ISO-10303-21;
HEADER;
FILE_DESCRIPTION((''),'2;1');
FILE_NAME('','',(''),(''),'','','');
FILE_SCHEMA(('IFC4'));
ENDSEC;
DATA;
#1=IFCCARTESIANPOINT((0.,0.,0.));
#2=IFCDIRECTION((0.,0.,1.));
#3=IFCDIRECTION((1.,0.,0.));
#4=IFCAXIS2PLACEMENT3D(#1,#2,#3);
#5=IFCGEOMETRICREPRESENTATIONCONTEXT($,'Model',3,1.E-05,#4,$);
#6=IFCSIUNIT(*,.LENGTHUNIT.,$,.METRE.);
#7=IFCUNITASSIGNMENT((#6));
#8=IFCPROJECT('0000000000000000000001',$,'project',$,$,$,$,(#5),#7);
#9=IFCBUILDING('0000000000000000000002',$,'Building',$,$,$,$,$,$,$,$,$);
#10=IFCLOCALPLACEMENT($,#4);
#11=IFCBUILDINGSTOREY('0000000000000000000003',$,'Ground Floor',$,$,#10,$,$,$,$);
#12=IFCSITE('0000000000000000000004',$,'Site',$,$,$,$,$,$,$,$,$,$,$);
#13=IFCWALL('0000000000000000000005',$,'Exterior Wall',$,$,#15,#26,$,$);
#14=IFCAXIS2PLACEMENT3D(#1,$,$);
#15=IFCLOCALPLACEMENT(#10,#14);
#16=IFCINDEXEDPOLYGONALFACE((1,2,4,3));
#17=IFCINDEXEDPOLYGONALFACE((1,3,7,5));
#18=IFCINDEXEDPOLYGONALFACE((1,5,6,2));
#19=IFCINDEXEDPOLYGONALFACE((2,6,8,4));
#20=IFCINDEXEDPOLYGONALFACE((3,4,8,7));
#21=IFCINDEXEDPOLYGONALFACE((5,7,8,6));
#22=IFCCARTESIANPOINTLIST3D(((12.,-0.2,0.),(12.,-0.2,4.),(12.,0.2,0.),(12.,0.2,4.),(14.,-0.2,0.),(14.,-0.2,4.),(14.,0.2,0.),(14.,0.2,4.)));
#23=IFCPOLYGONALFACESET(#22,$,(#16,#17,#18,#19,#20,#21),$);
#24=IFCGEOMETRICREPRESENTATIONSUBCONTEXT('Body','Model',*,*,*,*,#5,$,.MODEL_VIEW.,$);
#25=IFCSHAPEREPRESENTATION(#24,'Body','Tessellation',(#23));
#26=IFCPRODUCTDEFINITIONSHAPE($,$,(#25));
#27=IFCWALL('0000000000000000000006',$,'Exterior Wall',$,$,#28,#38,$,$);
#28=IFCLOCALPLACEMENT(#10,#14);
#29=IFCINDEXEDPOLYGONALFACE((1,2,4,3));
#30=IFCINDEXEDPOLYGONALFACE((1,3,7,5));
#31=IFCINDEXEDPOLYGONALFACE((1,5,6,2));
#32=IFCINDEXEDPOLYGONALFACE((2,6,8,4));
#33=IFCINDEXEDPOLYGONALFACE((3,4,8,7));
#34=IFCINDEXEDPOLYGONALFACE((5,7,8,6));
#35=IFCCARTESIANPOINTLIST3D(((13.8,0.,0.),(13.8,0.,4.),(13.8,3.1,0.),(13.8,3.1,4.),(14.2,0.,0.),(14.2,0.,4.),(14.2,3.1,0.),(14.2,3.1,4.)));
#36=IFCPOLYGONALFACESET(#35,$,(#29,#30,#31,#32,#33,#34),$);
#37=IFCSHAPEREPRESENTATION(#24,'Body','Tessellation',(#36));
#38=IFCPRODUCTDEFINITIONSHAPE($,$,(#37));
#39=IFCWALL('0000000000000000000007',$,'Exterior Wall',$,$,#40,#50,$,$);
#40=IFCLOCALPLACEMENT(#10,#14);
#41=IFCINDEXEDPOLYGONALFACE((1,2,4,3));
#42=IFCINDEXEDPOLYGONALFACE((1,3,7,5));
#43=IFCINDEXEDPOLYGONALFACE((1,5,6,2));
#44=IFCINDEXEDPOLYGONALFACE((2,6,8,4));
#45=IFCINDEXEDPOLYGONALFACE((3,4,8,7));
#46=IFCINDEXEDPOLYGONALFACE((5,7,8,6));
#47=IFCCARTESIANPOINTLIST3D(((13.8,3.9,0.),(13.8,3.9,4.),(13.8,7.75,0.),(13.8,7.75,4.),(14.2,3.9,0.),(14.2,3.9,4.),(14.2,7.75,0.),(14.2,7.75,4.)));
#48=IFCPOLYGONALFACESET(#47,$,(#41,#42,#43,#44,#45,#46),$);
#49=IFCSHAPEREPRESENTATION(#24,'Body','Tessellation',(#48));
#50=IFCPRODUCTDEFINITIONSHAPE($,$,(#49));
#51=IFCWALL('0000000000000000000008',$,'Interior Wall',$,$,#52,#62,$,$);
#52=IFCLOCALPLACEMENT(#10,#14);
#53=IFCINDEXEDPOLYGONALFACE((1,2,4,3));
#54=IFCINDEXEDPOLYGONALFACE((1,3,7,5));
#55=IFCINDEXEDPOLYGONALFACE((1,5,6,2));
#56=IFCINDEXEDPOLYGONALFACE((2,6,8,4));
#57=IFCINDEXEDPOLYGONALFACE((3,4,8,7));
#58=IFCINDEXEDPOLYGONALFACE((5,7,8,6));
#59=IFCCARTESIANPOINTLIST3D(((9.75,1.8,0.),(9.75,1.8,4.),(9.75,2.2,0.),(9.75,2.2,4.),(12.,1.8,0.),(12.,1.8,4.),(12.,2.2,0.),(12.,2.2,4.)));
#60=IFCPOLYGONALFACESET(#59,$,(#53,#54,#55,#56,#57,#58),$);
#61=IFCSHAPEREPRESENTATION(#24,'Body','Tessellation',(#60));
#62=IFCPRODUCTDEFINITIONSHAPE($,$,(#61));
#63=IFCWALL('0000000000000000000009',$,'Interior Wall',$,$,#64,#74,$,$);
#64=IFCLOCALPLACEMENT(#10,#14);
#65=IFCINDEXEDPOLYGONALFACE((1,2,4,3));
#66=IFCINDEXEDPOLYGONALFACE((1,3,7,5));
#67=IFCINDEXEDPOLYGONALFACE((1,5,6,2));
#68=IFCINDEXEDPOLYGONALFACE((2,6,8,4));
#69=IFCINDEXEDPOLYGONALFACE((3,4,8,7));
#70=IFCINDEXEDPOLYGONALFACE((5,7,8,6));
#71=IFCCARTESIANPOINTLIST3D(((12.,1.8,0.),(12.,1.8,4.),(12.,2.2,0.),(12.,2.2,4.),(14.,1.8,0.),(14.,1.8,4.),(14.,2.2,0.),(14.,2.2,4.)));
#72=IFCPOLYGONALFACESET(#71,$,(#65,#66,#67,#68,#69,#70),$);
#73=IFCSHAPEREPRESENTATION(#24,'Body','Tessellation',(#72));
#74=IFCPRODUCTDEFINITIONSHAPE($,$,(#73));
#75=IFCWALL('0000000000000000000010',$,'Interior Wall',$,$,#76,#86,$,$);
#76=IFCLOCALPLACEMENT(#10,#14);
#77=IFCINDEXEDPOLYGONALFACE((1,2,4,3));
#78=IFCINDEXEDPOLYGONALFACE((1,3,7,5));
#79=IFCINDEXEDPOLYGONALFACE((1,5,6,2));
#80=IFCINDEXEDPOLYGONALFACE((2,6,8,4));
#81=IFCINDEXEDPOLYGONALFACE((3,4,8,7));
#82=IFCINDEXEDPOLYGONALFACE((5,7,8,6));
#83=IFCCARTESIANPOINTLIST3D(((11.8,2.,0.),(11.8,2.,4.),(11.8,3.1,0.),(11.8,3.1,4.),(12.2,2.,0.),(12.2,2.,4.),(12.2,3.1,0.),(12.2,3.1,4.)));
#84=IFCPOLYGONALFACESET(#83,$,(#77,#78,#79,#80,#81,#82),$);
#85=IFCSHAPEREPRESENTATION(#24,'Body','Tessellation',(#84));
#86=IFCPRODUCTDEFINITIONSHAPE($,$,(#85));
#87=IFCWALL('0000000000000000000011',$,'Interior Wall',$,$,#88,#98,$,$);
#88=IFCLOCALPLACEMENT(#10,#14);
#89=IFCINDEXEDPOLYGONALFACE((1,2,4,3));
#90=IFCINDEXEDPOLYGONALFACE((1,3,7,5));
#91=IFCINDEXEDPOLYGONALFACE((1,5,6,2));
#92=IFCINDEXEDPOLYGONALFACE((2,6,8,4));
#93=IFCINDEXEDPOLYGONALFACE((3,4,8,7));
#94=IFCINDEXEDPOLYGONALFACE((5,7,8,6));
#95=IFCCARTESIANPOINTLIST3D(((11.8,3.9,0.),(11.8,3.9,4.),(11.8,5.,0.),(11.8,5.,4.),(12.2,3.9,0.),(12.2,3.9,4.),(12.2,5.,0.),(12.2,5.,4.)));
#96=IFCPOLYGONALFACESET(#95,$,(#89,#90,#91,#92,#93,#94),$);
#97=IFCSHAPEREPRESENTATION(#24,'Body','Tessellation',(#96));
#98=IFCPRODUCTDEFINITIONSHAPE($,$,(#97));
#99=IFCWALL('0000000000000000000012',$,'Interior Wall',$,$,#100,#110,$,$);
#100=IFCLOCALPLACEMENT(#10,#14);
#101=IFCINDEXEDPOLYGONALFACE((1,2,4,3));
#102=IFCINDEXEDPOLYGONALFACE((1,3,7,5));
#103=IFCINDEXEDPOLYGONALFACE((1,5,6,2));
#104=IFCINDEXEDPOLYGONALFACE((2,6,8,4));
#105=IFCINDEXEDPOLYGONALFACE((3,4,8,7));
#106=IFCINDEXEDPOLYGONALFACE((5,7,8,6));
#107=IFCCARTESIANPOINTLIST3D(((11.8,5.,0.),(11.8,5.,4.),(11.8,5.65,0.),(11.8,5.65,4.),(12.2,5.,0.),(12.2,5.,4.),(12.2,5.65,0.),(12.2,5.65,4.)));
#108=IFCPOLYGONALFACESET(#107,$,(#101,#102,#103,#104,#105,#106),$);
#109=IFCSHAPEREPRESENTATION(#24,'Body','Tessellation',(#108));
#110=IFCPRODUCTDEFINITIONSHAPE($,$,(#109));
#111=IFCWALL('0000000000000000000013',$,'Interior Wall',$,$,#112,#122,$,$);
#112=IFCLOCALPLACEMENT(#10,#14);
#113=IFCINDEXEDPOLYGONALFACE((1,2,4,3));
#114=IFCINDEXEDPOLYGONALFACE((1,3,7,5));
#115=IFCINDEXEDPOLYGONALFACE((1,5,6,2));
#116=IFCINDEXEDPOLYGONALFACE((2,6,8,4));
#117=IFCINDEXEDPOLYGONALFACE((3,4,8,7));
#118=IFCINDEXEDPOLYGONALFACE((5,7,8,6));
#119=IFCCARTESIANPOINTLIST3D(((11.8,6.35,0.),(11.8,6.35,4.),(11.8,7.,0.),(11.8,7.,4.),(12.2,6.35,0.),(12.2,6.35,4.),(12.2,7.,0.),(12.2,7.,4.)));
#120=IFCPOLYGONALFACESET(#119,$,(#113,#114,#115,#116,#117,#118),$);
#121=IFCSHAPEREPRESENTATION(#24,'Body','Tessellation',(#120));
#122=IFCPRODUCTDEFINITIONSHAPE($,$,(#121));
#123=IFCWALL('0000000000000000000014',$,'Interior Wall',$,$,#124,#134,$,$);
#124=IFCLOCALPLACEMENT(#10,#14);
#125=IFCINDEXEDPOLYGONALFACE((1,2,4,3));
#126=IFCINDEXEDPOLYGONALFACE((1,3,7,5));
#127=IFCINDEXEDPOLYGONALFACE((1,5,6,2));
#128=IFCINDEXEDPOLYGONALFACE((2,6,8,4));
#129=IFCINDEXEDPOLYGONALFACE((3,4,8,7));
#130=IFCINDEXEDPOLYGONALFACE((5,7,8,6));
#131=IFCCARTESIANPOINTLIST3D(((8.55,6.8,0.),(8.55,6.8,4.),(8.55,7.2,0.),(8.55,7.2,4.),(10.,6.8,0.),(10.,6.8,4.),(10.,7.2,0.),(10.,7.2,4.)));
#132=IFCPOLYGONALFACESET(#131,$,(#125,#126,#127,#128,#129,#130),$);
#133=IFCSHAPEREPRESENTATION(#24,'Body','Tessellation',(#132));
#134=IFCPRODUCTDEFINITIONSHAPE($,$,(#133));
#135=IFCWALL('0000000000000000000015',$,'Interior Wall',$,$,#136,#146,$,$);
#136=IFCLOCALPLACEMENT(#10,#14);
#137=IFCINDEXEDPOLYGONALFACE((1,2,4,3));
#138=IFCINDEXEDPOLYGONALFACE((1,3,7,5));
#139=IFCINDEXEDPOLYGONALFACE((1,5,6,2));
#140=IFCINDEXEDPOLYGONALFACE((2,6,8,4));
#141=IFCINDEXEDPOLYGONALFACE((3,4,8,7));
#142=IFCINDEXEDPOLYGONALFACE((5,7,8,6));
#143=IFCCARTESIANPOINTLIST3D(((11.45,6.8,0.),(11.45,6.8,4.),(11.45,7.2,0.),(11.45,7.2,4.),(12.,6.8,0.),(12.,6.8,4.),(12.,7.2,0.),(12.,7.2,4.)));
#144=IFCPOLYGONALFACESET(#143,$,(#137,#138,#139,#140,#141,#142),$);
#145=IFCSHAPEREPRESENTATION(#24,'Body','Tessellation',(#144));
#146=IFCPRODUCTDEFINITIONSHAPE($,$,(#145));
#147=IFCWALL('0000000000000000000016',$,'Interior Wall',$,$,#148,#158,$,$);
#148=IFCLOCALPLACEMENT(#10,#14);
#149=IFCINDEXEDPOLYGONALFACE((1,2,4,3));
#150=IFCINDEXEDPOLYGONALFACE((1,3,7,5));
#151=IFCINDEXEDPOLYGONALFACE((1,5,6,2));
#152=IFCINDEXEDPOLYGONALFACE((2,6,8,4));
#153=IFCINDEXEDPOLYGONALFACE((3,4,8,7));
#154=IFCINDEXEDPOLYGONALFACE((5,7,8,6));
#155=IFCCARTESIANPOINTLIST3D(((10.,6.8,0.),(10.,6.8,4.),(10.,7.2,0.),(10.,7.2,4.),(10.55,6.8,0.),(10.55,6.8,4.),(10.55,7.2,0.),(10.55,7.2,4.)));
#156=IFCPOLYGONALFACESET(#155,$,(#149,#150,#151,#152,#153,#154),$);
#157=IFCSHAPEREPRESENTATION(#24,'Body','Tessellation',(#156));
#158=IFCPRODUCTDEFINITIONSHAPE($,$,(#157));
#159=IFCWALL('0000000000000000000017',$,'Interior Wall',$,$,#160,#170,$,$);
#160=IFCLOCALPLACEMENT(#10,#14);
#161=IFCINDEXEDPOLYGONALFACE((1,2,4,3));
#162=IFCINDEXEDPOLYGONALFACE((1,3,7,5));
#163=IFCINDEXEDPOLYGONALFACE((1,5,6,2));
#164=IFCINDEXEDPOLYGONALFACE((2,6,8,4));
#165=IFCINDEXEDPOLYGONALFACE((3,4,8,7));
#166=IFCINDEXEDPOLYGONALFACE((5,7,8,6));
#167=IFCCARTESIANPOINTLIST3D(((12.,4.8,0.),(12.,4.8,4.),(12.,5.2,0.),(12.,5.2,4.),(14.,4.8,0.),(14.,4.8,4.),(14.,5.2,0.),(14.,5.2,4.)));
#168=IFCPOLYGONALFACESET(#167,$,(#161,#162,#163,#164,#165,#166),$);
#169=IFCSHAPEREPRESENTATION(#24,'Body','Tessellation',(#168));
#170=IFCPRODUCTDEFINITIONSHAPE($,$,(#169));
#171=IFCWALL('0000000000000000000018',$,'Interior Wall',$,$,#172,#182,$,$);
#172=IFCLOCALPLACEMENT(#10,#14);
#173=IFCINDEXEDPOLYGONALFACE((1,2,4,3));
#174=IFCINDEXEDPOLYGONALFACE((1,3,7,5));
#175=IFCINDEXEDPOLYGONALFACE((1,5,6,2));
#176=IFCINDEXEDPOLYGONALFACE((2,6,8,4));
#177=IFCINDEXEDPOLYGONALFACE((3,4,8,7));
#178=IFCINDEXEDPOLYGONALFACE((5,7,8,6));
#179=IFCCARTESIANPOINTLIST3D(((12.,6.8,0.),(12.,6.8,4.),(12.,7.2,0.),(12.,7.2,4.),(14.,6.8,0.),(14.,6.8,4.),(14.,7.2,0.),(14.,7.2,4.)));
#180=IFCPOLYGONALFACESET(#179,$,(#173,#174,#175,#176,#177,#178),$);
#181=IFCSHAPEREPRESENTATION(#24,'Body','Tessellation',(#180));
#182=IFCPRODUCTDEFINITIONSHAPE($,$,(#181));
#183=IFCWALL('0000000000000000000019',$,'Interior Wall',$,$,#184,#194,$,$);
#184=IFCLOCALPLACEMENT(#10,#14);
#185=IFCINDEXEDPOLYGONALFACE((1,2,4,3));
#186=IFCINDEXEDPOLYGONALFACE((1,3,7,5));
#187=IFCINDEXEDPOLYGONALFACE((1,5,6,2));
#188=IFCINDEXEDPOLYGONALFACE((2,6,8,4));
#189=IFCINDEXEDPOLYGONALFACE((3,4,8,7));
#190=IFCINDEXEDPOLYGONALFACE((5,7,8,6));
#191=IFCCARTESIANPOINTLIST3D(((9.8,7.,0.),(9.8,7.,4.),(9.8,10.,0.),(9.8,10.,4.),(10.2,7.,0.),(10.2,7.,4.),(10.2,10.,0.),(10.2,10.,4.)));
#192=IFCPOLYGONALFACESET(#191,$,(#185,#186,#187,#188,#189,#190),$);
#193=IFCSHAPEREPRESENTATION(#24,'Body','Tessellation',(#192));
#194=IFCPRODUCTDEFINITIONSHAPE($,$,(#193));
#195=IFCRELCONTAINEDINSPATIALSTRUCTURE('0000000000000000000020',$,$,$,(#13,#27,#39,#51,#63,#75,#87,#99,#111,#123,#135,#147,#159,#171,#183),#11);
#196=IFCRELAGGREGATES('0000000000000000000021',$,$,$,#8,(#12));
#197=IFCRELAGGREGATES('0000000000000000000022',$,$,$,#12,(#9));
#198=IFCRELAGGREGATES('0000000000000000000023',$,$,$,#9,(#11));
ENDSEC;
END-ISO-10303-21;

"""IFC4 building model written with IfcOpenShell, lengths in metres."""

from ifc_helpers import new_model, si_unit, frame, origin_with_axes, place, context, subcontext, project, spatial, indexed_curve, outline, extrude, element, save


model = new_model("IFC4")

# Units and contexts
model_context = context("Model", 3, precision=1e-05, world=origin_with_axes())
body_context = subcontext(model_context, "Body", "Model", "MODEL_VIEW")
ifc_project = project(units=[si_unit("LENGTHUNIT", "METRE")], contexts=[model_context])

# Site, building, storey
site = spatial("IfcSite", under=ifc_project, Name="Site")
building = spatial("IfcBuilding", under=site, Name="Building")
storey_placement = place(None, origin_with_axes())
storey = spatial("IfcBuildingStorey", under=building, at=storey_placement, Name="Ground Floor")

# Walls
wall_1_placement = place(storey_placement, frame((12.0, 0.0, 0.0), z_axis=(0.0, 0.0, 1.0), x_axis=(1.0, 0.0, 0.0)))
element("IfcWall", 1, at=wall_1_placement, inside=storey, Name="Exterior Wall", context=body_context, shape_type="SweptSolid", body=[
    extrude(outline(indexed_curve([(0.0, 0.0), (0.0, 0.4), (2.0, 0.4), (2.0, 0.0), (0.0, 0.0)], self_intersect=False)), frame((0.0, -0.2, 0.0), z_axis=(0.0, 0.0, 1.0), x_axis=(1.0, 0.0, 0.0)), (0.0, 0.0, 1.0), 4.0),
])
wall_2_placement = place(storey_placement, frame((14.0, 0.0, 0.0), z_axis=(0.0, 0.0, 1.0), x_axis=(0.0, 1.0, 0.0)))
element("IfcWall", 2, at=wall_2_placement, inside=storey, Name="Exterior Wall", context=body_context, shape_type="SweptSolid", body=[
    extrude(outline(indexed_curve([(0.0, 0.0), (0.0, 0.4), (3.1, 0.4), (3.1, 0.0), (0.0, 0.0)], self_intersect=False)), frame((0.0, -0.2, 0.0), z_axis=(0.0, 0.0, 1.0), x_axis=(1.0, 0.0, 0.0)), (0.0, 0.0, 1.0), 4.0),
])
wall_3_placement = place(storey_placement, frame((14.0, 3.9, 0.0), z_axis=(0.0, 0.0, 1.0), x_axis=(0.0, 1.0, 0.0)))
element("IfcWall", 3, at=wall_3_placement, inside=storey, Name="Exterior Wall", context=body_context, shape_type="SweptSolid", body=[
    extrude(outline(indexed_curve([(0.0, 0.0), (0.0, 0.4), (3.85, 0.4), (3.85, 0.0), (0.0, 0.0)], self_intersect=False)), frame((0.0, -0.2, 0.0), z_axis=(0.0, 0.0, 1.0), x_axis=(1.0, 0.0, 0.0)), (0.0, 0.0, 1.0), 4.0),
])
wall_4_placement = place(storey_placement, frame((12.0, 2.0, 0.0), z_axis=(0.0, 0.0, 1.0), x_axis=(-1.0, 0.0, 0.0)))
element("IfcWall", 4, at=wall_4_placement, inside=storey, Name="Interior Wall", context=body_context, shape_type="SweptSolid", body=[
    extrude(outline(indexed_curve([(0.0, 0.0), (0.0, 0.4), (2.25, 0.4), (2.25, 0.0), (0.0, 0.0)], self_intersect=False)), frame((0.0, -0.2, 0.0), z_axis=(0.0, 0.0, 1.0), x_axis=(1.0, 0.0, 0.0)), (0.0, 0.0, 1.0), 4.0),
])
wall_5_placement = place(storey_placement, frame((14.0, 2.0, 0.0), z_axis=(0.0, 0.0, 1.0), x_axis=(-1.0, 0.0, 0.0)))
element("IfcWall", 5, at=wall_5_placement, inside=storey, Name="Interior Wall", context=body_context, shape_type="SweptSolid", body=[
    extrude(outline(indexed_curve([(0.0, 0.0), (0.0, 0.4), (2.0, 0.4), (2.0, 0.0), (0.0, 0.0)], self_intersect=False)), frame((0.0, -0.2, 0.0), z_axis=(0.0, 0.0, 1.0), x_axis=(1.0, 0.0, 0.0)), (0.0, 0.0, 1.0), 4.0),
])
for number, where, z_axis, x_axis, name in (
    (6, (12.0, 2.0, 0.0), (0.0, 0.0, 1.0), (0.0, 1.0, 0.0), "Interior Wall"),
    (7, (12.0, 3.9, 0.0), (0.0, 0.0, 1.0), (0.0, 1.0, 0.0), "Interior Wall"),
):
    element("IfcWall", number, at=place(storey_placement, frame(where, z_axis=z_axis, x_axis=x_axis)), inside=storey, Name=name, context=body_context, shape_type="SweptSolid", body=[
        extrude(outline(indexed_curve([(0.0, 0.0), (0.0, 0.4), (1.1, 0.4), (1.1, 0.0), (0.0, 0.0)], self_intersect=False)), frame((0.0, -0.2, 0.0), z_axis=(0.0, 0.0, 1.0), x_axis=(1.0, 0.0, 0.0)), (0.0, 0.0, 1.0), 4.0),
    ])
for number, where, z_axis, x_axis, name in (
    (8, (12.0, 5.0, 0.0), (0.0, 0.0, 1.0), (0.0, 1.0, 0.0), "Interior Wall"),
    (9, (12.0, 6.35, 0.0), (0.0, 0.0, 1.0), (0.0, 1.0, 0.0), "Interior Wall"),
):
    element("IfcWall", number, at=place(storey_placement, frame(where, z_axis=z_axis, x_axis=x_axis)), inside=storey, Name=name, context=body_context, shape_type="SweptSolid", body=[
        extrude(outline(indexed_curve([(0.0, 0.0), (0.0, 0.4), (0.65, 0.4), (0.65, 0.0), (0.0, 0.0)], self_intersect=False)), frame((0.0, -0.2, 0.0), z_axis=(0.0, 0.0, 1.0), x_axis=(1.0, 0.0, 0.0)), (0.0, 0.0, 1.0), 4.0),
    ])
wall_6_placement = place(storey_placement, frame((10.0, 7.0, 0.0), z_axis=(0.0, 0.0, 1.0), x_axis=(-1.0, 0.0, 0.0)))
element("IfcWall", 10, at=wall_6_placement, inside=storey, Name="Interior Wall", context=body_context, shape_type="SweptSolid", body=[
    extrude(outline(indexed_curve([(0.0, 0.0), (0.0, 0.4), (1.45, 0.4), (1.45, 0.0), (0.0, 0.0)], self_intersect=False)), frame((0.0, -0.2, 0.0), z_axis=(0.0, 0.0, 1.0), x_axis=(1.0, 0.0, 0.0)), (0.0, 0.0, 1.0), 4.0),
])
for number, where, z_axis, x_axis, name in (
    (11, (12.0, 7.0, 0.0), (0.0, 0.0, 1.0), (-1.0, 0.0, 0.0), "Interior Wall"),
    (12, (10.55, 7.0, 0.0), (0.0, 0.0, 1.0), (-1.0, 0.0, 0.0), "Interior Wall"),
):
    element("IfcWall", number, at=place(storey_placement, frame(where, z_axis=z_axis, x_axis=x_axis)), inside=storey, Name=name, context=body_context, shape_type="SweptSolid", body=[
        extrude(outline(indexed_curve([(0.0, 0.0), (0.0, 0.4), (0.55, 0.4), (0.55, 0.0), (0.0, 0.0)], self_intersect=False)), frame((0.0, -0.2, 0.0), z_axis=(0.0, 0.0, 1.0), x_axis=(1.0, 0.0, 0.0)), (0.0, 0.0, 1.0), 4.0),
    ])
for number, where, z_axis, x_axis, name in (
    (13, (14.0, 5.0, 0.0), (0.0, 0.0, 1.0), (-1.0, 0.0, 0.0), "Interior Wall"),
    (14, (14.0, 7.0, 0.0), (0.0, 0.0, 1.0), (-1.0, 0.0, 0.0), "Interior Wall"),
):
    element("IfcWall", number, at=place(storey_placement, frame(where, z_axis=z_axis, x_axis=x_axis)), inside=storey, Name=name, context=body_context, shape_type="SweptSolid", body=[
        extrude(outline(indexed_curve([(0.0, 0.0), (0.0, 0.4), (2.0, 0.4), (2.0, 0.0), (0.0, 0.0)], self_intersect=False)), frame((0.0, -0.2, 0.0), z_axis=(0.0, 0.0, 1.0), x_axis=(1.0, 0.0, 0.0)), (0.0, 0.0, 1.0), 4.0),
    ])
wall_7_placement = place(storey_placement, frame((10.0, 7.0, 0.0), z_axis=(0.0, 0.0, 1.0), x_axis=(0.0, 1.0, 0.0)))
element("IfcWall", 15, at=wall_7_placement, inside=storey, Name="Interior Wall", context=body_context, shape_type="SweptSolid", body=[
    extrude(outline(indexed_curve([(0.0, 0.0), (0.0, 0.4), (3.0, 0.4), (3.0, 0.0), (0.0, 0.0)], self_intersect=False)), frame((0.0, -0.2, 0.0), z_axis=(0.0, 0.0, 1.0), x_axis=(1.0, 0.0, 0.0)), (0.0, 0.0, 1.0), 4.0),
])

save(model, "model.ifc")
